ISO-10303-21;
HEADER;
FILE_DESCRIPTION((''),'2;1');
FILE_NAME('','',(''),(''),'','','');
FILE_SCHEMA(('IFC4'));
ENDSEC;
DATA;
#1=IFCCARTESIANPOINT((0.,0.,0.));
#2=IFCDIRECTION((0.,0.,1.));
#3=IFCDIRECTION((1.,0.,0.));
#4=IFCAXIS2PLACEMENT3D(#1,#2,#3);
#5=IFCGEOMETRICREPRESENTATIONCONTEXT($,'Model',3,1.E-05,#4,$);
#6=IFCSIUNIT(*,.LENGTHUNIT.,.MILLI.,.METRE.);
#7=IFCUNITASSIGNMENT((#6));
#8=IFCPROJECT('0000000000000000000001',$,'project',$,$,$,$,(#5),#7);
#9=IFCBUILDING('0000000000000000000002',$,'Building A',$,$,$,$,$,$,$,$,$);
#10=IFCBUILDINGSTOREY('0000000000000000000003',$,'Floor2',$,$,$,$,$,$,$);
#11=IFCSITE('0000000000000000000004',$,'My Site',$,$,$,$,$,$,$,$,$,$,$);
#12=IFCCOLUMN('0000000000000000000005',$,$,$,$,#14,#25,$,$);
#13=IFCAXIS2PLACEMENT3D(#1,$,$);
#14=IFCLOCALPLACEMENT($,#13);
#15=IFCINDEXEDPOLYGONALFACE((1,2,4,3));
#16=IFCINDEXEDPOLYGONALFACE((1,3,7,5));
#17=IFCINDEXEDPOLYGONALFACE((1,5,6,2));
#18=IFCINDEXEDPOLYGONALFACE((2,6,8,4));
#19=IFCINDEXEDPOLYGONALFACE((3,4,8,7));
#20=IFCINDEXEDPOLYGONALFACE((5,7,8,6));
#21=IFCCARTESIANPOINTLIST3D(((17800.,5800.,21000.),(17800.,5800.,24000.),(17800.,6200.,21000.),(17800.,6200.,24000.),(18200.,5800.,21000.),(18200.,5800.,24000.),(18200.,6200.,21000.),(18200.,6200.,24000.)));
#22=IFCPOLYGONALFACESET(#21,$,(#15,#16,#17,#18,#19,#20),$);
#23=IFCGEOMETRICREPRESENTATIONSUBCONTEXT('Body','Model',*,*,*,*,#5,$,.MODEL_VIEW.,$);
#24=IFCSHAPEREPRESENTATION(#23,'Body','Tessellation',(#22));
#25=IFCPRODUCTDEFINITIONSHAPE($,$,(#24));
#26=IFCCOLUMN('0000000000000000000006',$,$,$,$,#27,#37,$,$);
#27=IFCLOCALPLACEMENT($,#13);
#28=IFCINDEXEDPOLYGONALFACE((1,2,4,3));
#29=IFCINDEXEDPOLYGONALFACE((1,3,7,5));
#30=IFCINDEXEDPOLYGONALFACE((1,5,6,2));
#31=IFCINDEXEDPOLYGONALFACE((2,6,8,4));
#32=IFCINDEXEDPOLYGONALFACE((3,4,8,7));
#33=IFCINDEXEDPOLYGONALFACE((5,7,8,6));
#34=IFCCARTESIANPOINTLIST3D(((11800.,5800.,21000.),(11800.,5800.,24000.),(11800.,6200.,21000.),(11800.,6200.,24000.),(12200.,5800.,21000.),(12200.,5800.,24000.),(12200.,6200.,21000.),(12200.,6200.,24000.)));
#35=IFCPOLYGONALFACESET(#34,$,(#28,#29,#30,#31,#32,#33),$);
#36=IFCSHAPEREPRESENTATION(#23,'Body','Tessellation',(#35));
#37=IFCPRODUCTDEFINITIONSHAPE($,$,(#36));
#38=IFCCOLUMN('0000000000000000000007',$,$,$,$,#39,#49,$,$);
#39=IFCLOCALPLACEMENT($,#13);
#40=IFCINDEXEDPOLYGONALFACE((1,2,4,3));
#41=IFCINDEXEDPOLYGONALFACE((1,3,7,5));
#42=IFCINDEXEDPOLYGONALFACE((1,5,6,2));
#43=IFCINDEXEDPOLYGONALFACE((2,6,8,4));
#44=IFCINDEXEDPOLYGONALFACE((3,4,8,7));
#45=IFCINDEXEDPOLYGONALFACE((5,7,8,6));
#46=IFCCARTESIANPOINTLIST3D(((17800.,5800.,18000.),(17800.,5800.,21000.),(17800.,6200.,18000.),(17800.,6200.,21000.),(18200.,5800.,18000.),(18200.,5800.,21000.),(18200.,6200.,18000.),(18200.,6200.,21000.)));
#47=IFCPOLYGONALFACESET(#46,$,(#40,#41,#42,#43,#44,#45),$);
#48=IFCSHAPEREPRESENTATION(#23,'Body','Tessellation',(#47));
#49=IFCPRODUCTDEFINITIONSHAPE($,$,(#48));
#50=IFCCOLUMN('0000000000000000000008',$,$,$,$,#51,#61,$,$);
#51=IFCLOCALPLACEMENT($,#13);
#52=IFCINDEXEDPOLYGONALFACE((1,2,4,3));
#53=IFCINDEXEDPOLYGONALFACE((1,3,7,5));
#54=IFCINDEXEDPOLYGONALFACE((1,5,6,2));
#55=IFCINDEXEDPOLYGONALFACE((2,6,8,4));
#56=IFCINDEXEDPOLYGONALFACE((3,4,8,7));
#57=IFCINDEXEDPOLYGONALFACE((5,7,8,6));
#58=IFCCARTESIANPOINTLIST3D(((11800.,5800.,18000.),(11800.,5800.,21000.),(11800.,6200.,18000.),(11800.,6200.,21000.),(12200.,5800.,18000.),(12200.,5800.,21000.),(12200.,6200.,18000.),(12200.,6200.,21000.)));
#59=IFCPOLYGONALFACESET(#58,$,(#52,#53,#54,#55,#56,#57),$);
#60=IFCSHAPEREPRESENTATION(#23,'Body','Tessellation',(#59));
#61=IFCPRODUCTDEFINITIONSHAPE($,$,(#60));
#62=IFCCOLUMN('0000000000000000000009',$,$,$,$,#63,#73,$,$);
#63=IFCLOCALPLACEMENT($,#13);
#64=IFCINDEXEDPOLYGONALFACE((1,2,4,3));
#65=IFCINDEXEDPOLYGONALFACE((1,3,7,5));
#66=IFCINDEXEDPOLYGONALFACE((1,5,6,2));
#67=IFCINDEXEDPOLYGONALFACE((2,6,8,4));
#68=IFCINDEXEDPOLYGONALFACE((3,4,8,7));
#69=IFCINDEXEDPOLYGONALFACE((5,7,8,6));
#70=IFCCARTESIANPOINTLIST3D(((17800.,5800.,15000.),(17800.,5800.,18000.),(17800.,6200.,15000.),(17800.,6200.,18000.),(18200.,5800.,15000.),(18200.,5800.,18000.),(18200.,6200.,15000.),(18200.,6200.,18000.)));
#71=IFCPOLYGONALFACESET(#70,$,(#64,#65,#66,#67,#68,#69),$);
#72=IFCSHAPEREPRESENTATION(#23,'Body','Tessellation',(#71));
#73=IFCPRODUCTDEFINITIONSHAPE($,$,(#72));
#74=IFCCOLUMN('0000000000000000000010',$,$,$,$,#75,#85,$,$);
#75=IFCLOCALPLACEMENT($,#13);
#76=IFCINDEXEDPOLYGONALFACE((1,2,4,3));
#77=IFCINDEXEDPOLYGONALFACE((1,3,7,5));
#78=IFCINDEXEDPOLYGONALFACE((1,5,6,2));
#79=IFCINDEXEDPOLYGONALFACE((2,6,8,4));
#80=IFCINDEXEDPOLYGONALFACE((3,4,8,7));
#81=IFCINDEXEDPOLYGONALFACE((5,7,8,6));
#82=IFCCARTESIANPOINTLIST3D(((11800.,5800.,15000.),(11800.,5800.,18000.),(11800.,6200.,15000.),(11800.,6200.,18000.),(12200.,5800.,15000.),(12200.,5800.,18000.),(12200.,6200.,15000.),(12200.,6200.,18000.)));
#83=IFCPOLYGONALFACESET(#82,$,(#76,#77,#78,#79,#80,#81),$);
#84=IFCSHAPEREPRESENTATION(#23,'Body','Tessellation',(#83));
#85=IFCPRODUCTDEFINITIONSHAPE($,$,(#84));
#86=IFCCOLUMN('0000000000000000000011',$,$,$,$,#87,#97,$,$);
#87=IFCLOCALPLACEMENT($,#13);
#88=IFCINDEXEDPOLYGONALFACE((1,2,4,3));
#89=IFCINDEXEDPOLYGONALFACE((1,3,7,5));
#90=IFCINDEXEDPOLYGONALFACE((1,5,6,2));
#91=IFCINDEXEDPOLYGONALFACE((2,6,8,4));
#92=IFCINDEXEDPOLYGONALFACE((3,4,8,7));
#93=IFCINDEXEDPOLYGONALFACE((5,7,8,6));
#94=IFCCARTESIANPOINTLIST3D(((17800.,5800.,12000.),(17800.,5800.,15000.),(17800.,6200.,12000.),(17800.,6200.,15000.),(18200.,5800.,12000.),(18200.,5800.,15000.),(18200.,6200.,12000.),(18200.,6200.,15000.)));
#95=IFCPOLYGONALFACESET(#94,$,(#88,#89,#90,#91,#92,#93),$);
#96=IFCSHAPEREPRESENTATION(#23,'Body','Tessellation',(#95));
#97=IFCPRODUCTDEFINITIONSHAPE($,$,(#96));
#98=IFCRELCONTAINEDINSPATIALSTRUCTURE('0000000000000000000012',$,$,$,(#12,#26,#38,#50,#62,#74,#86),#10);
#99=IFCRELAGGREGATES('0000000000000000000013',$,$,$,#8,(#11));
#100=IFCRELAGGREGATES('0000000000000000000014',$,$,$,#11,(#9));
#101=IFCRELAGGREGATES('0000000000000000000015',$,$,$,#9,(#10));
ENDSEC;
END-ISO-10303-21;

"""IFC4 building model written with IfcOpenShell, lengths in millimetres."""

from ifc_helpers import new_model, si_unit, frame, origin_with_axes, place, context, subcontext, project, spatial, line, indexed_curve, outline, extrude, element, save


model = new_model("IFC4")

# Units and contexts
model_context = context("Model", 3, precision=1e-05, world=origin_with_axes())
body_context = subcontext(model_context, "Body", "Model", "MODEL_VIEW")
ifc_project = project(units=[si_unit("LENGTHUNIT", "METRE", prefix="MILLI")], contexts=[model_context])

# Site, building, storey
site = spatial("IfcSite", under=ifc_project, Name="My Site")
building = spatial("IfcBuilding", under=site, Name="Building A")
storey = spatial("IfcBuildingStorey", under=building, Name="Floor2")

# Columns
for number, where, z_axis, x_axis in (
    (1, (18000.0, 6000.0, 21000.0), (0.0, 0.0, 1.0), (1.0, 0.0, 0.0)),
    (2, (12000.0, 6000.0, 21000.0), (0.0, 0.0, 1.0), (1.0, 0.0, 0.0)),
    (3, (18000.0, 6000.0, 18000.0), (0.0, 0.0, 1.0), (1.0, 0.0, 0.0)),
    (4, (12000.0, 6000.0, 18000.0), (0.0, 0.0, 1.0), (1.0, 0.0, 0.0)),
    (5, (18000.0, 6000.0, 15000.0), (0.0, 0.0, 1.0), (1.0, 0.0, 0.0)),
    (6, (12000.0, 6000.0, 15000.0), (0.0, 0.0, 1.0), (1.0, 0.0, 0.0)),
    (7, (18000.0, 6000.0, 12000.0), (0.0, 0.0, 1.0), (1.0, 0.0, 0.0)),
):
    element("IfcColumn", number, at=place(None, frame(where, z_axis=z_axis, x_axis=x_axis)), inside=storey, context=body_context, shape_type="SweptSolid", body=[
        extrude(outline(indexed_curve([(-200.0, -200.0), (200.0, -200.0), (200.0, 200.0), (-200.0, 200.0)], segments=[line(1, 2, 3, 4, 1)])), origin_with_axes(), (0.0, 0.0, 1.0), 3000.0),
    ])

save(model, "model.ifc")
